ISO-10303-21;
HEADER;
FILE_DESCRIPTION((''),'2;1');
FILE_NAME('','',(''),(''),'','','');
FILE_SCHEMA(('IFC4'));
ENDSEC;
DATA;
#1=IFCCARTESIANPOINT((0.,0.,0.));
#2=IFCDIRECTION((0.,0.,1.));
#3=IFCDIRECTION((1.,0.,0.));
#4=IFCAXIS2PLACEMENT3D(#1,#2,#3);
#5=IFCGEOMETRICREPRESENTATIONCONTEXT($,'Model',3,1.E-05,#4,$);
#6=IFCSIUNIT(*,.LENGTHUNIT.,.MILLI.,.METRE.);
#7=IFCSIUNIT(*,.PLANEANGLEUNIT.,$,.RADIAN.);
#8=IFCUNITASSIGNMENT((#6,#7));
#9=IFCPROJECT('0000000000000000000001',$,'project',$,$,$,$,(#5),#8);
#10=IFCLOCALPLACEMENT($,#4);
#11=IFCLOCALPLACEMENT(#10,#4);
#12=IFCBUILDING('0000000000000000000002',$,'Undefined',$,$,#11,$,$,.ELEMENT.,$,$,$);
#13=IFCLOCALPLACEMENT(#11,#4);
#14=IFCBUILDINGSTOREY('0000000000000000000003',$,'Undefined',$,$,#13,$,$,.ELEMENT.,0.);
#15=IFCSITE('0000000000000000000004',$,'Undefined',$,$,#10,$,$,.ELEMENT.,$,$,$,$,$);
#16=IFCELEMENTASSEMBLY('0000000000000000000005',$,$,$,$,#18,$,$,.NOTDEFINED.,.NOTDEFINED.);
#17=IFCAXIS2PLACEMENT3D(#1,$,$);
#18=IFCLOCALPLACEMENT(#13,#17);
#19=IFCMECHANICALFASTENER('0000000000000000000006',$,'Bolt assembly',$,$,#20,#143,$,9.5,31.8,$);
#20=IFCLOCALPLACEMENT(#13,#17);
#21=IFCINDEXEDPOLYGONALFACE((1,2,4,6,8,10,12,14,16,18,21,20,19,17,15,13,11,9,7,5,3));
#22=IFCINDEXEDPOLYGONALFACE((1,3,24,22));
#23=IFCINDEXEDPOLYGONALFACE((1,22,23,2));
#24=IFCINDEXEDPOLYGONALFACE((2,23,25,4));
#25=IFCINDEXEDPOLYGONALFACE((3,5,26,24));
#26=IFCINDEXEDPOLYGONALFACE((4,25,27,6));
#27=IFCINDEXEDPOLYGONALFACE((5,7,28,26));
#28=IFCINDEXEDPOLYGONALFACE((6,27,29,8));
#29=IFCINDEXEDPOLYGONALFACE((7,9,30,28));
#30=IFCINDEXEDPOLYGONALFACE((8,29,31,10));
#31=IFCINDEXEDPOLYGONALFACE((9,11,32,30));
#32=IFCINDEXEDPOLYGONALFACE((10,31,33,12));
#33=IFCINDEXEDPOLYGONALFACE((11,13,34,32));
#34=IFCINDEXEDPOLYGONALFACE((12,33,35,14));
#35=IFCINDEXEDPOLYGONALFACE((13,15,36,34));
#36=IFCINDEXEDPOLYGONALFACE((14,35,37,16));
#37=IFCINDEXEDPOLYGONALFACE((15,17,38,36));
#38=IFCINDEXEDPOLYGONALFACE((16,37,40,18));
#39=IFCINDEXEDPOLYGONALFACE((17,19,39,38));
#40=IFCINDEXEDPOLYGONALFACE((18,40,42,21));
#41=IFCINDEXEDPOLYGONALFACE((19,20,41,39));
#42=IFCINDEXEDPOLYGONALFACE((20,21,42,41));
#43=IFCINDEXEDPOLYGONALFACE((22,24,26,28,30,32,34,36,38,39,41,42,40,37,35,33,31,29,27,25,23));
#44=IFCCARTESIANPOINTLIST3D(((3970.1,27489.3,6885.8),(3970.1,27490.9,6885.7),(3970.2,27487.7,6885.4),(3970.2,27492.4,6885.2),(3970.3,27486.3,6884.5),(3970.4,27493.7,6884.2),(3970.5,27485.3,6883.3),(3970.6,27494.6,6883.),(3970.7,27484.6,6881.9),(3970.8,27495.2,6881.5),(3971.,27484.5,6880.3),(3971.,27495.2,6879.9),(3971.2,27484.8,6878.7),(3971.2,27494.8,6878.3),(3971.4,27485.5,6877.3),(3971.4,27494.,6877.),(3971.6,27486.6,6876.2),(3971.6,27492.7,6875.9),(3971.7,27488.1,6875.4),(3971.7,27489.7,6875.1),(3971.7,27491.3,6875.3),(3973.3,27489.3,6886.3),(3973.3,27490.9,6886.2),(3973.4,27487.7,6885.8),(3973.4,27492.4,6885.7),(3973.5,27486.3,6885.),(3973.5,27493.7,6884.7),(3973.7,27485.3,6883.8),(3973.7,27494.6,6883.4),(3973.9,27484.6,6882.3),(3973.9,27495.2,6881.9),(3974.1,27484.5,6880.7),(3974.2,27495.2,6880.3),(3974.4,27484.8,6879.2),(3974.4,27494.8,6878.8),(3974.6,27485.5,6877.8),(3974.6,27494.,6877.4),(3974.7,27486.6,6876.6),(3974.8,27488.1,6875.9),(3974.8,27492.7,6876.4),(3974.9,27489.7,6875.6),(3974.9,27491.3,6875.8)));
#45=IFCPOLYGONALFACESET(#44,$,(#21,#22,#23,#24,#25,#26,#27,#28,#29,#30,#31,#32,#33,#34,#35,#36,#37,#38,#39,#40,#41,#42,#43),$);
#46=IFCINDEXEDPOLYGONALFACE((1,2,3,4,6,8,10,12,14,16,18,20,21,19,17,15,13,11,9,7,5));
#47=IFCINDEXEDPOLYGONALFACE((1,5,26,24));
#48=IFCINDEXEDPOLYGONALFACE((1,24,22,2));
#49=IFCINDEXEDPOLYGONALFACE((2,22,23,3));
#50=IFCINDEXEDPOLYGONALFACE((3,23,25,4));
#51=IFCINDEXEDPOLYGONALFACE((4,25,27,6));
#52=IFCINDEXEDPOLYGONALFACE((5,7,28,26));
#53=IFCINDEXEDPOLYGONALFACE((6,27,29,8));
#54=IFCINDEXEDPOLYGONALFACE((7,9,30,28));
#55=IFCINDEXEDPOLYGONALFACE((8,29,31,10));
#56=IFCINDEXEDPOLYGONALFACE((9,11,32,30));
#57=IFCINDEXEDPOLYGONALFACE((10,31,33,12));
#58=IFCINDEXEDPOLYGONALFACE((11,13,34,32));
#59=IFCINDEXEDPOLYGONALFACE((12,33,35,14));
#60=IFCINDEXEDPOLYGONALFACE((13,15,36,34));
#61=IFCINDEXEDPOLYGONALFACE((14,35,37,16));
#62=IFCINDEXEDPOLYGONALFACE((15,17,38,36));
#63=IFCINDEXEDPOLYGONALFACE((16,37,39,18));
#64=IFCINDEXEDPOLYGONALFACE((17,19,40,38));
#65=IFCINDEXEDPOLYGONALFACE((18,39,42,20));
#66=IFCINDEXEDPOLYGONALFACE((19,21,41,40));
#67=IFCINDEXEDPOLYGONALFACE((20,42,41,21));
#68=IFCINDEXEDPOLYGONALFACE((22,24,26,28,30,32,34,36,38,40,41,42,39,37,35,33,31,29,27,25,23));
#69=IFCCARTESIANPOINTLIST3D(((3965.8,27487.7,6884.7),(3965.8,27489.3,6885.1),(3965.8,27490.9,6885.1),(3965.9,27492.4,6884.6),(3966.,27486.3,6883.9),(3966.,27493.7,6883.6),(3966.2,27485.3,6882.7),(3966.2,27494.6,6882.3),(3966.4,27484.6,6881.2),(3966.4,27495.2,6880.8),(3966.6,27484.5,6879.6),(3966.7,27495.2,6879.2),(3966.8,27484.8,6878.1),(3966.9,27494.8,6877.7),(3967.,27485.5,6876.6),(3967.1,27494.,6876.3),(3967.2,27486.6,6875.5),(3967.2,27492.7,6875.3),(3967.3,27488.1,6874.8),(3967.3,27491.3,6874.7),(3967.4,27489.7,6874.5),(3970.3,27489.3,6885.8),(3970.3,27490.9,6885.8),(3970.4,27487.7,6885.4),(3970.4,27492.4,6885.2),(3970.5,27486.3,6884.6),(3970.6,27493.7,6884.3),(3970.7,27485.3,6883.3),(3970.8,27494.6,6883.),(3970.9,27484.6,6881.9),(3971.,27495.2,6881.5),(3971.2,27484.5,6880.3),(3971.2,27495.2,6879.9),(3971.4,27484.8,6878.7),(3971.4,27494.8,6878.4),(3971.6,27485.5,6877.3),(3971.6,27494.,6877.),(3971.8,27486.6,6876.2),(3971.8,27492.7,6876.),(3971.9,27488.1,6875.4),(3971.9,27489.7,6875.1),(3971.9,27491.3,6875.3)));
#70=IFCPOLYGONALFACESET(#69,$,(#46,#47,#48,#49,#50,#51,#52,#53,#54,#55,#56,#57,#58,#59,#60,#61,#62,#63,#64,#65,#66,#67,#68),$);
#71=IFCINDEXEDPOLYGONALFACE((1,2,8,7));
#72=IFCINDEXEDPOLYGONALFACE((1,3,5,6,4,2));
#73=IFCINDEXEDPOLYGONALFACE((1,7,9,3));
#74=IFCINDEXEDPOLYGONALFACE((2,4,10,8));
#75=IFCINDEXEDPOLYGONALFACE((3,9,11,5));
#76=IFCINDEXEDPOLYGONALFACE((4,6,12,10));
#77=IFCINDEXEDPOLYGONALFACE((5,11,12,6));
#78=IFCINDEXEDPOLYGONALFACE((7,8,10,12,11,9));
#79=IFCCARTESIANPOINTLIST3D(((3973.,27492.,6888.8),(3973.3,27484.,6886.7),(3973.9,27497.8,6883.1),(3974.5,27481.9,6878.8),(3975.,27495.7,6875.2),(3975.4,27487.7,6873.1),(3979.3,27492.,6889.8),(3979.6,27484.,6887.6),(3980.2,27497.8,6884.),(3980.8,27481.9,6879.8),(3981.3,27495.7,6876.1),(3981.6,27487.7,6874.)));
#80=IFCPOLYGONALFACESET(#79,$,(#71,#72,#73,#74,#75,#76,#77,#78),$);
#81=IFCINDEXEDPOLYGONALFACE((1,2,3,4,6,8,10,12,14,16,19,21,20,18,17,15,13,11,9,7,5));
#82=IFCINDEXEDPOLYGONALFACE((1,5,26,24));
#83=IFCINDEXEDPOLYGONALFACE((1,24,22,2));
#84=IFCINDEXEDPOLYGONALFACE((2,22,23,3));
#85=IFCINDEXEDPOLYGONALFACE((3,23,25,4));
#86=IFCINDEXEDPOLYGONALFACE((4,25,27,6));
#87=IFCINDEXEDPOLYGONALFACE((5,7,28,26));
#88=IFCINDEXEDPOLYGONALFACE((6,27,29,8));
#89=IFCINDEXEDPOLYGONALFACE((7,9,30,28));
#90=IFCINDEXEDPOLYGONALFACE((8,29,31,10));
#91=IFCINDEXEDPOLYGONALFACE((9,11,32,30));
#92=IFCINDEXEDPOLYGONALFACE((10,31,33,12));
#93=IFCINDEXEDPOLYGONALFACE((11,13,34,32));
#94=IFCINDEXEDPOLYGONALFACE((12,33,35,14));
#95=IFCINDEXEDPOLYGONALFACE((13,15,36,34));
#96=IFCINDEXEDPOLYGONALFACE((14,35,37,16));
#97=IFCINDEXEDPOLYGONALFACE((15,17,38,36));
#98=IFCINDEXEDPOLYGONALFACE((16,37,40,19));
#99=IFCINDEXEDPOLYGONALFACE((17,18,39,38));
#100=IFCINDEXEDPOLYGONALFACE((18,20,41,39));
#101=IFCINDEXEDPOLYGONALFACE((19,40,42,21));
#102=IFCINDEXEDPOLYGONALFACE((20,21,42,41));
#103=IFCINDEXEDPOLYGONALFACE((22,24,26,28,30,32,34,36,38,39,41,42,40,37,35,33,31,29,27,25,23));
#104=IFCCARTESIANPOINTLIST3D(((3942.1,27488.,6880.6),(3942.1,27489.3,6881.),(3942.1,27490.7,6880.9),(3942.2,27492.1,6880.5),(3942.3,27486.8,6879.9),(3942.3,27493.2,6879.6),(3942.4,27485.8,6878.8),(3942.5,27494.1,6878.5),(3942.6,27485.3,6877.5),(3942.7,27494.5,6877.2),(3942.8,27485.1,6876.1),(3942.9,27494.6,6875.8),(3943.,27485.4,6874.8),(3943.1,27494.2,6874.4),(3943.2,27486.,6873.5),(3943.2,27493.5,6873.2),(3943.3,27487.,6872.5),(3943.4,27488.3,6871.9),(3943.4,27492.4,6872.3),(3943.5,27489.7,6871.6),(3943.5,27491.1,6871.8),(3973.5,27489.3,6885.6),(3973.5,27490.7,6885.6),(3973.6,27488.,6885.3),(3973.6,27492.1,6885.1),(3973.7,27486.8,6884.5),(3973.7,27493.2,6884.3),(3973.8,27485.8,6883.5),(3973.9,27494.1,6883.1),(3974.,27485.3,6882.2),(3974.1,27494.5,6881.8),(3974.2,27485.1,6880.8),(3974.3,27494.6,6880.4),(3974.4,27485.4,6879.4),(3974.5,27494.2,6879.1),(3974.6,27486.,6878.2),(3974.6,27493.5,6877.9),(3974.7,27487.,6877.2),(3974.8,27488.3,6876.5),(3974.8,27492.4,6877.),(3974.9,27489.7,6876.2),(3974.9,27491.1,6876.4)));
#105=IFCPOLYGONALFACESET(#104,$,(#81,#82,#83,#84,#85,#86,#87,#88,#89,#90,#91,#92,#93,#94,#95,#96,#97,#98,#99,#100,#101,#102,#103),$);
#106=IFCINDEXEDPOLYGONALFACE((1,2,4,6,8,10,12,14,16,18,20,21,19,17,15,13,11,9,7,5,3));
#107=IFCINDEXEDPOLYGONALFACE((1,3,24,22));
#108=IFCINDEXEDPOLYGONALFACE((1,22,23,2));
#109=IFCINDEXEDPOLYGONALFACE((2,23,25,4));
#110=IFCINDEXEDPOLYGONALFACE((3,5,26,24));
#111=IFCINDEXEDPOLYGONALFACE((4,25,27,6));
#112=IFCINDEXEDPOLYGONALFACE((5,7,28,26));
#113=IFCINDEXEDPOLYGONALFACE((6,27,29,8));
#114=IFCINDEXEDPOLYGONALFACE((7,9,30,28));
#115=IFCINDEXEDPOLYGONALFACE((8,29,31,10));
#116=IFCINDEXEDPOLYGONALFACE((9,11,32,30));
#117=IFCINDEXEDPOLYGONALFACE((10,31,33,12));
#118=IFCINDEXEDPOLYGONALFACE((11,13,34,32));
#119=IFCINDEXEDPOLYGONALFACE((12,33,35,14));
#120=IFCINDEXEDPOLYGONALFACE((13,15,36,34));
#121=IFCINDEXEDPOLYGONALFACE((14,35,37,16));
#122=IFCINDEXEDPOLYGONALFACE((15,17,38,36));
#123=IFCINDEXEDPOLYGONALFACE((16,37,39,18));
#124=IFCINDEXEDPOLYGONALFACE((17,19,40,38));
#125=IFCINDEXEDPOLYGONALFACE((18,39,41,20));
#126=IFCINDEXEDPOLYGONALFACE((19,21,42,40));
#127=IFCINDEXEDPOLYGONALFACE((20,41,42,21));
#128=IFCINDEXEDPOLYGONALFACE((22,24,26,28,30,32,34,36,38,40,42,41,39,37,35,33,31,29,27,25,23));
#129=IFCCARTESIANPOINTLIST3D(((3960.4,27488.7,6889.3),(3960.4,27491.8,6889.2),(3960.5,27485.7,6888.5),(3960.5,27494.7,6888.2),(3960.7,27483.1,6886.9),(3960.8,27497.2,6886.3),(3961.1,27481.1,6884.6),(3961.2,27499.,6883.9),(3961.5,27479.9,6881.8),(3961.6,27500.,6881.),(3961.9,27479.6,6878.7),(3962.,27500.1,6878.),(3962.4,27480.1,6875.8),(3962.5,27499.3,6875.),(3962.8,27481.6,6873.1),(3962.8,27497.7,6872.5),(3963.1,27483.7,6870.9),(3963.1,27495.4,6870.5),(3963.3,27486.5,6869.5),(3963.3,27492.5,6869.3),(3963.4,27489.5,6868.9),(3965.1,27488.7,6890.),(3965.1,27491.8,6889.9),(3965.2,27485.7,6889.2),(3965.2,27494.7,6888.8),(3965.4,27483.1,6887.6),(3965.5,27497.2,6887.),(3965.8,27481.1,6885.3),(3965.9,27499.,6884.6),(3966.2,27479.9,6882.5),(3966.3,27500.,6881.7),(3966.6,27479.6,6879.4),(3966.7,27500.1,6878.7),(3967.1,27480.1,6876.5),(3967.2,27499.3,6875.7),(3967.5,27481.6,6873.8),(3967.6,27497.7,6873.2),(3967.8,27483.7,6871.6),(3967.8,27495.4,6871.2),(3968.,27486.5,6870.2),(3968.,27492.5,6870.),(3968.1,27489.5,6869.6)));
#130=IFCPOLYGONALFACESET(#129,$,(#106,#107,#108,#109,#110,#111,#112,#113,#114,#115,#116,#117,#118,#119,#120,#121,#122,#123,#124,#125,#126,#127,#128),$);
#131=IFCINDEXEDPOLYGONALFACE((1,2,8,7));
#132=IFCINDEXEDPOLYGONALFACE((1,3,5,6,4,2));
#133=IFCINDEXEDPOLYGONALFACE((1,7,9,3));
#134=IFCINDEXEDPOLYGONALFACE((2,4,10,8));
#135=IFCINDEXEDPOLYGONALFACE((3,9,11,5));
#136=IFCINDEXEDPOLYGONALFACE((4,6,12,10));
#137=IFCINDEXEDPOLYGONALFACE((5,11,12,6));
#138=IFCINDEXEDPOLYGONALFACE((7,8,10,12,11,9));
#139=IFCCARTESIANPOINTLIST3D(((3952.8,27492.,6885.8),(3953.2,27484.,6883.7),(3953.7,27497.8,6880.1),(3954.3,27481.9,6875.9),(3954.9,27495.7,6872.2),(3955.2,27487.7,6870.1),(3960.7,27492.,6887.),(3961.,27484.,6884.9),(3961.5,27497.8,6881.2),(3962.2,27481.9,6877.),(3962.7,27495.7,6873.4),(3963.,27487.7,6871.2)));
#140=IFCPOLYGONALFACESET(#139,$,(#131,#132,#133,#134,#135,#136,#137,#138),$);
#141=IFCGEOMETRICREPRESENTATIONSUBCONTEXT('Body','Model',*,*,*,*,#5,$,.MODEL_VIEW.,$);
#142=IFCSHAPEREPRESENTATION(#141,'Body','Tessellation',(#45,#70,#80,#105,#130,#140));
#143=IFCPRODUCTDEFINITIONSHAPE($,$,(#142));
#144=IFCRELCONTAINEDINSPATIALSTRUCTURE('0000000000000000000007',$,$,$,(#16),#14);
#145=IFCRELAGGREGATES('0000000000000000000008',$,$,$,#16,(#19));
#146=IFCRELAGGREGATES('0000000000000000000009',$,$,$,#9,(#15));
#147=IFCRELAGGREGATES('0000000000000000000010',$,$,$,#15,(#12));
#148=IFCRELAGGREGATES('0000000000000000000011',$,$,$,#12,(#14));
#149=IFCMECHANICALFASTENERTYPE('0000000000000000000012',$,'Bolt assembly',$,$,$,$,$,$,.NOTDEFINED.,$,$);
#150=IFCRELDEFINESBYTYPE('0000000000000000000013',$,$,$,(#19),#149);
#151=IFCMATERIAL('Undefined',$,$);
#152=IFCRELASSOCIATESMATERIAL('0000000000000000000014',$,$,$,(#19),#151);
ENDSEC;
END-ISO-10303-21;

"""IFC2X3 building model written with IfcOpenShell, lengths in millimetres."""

from ifc_helpers import new_model, si_unit, frame, origin_with_axes, origin_2d_with_axis, place, context, subcontext, project, spatial, polyline, circle, outline, extrude, source, transform, mapped, material, type_object, element, aggregate, save


model = new_model("IFC2X3")

# Units and contexts
model_context = context("Model", 3, precision=1e-05, world=origin_with_axes())
body_context = subcontext(model_context, "Body", "Model", "MODEL_VIEW")
ifc_project = project(units=[si_unit("LENGTHUNIT", "METRE", prefix="MILLI"), si_unit("PLANEANGLEUNIT", "RADIAN")], contexts=[model_context])

# Site, building, storey
site_placement = place(None, origin_with_axes())
site = spatial("IfcSite", under=ifc_project, at=site_placement, Name="Undefined", CompositionType="ELEMENT")
building_placement = place(site_placement, origin_with_axes())
building = spatial("IfcBuilding", under=site, at=building_placement, Name="Undefined", CompositionType="ELEMENT")
storey_placement = place(building_placement, origin_with_axes())
storey = spatial("IfcBuildingStorey", under=building, at=storey_placement, Name="Undefined", CompositionType="ELEMENT", Elevation=0.0)

# Element assembly
assembly_1_placement = place(storey_placement, origin_with_axes())
assembly_1 = element("IfcElementAssembly", 1, at=assembly_1_placement, inside=storey, AssemblyPlace="NOTDEFINED", PredefinedType="NOTDEFINED")

# Shared definitions
ifc_material_1 = material(Name="Undefined")
mechanical_fastener_type = type_object("IfcMechanicalFastenerType", Name="Bolt assembly")

# Mechanical fastener
shared_shape_1 = source(origin_with_axes(), body_context, "Body", "SweptSolid", [
    extrude(circle(Radius=5.4, at=origin_2d_with_axis()), frame((0.0, -3.1, 0.0), z_axis=(0.0, 1.0, 0.0), x_axis=(1.0, 0.0, 0.0)), (0.0, 0.0, 1.0), 3.2),
    extrude(circle(Radius=5.4, at=origin_2d_with_axis()), frame((0.0, -0.1, 0.0), z_axis=(0.0, 1.0, 0.0), x_axis=(1.0, 0.0, 0.0)), (0.0, 0.0, 1.0), 4.6),
    extrude(outline(polyline([(7.1, -4.1), (7.1, 4.1), (0.0, 8.2), (-7.1, 4.1), (-7.1, -4.1), (0.0, -8.2), (7.1, -4.1)])), frame((0.0, -9.6, 0.0), z_axis=(0.0, 1.0, 0.0), x_axis=(1.0, 0.0, 0.0)), (0.0, 0.0, 1.0), 6.3),
    extrude(circle(Radius=4.8, at=origin_2d_with_axis()), frame((0.0, -3.2, 0.0), z_axis=(0.0, 1.0, 0.0), x_axis=(1.0, 0.0, 0.0)), (0.0, 0.0, 1.0), 31.8),
    extrude(circle(Radius=10.3, at=origin_2d_with_axis()), frame((0.0, 4.5, 0.0), z_axis=(0.0, 1.0, 0.0), x_axis=(1.0, 0.0, 0.0)), (0.0, 0.0, 1.0), 4.8),
    extrude(outline(polyline([(7.1, -4.1), (7.1, 4.1), (0.0, 8.2), (-7.1, 4.1), (-7.1, -4.1), (0.0, -8.2), (7.1, -4.1)])), frame((0.0, 9.3, 0.0), z_axis=(0.0, 1.0, 0.0), x_axis=(1.0, 0.0, 0.0)), (0.0, 0.0, 1.0), 7.9),
])
mechanical_fastener_1_placement = place(assembly_1_placement, frame((3971.0, 27489.9, 6880.5), z_axis=(-0.103381, -0.707107, 0.699509), x_axis=(-0.103381, 0.707107, 0.699509)))
mechanical_fastener_1 = element("IfcMechanicalFastener", 2, at=mechanical_fastener_1_placement, type_object=mechanical_fastener_type, material=ifc_material_1, Name="Bolt assembly", NominalDiameter=9.5, NominalLength=31.8, context=body_context, shape_type="MappedRepresentation", body=[
    mapped(shared_shape_1, transform((0.0, 0.0, 0.0))),
])
aggregate(assembly_1, [mechanical_fastener_1])

save(model, "model.ifc")
